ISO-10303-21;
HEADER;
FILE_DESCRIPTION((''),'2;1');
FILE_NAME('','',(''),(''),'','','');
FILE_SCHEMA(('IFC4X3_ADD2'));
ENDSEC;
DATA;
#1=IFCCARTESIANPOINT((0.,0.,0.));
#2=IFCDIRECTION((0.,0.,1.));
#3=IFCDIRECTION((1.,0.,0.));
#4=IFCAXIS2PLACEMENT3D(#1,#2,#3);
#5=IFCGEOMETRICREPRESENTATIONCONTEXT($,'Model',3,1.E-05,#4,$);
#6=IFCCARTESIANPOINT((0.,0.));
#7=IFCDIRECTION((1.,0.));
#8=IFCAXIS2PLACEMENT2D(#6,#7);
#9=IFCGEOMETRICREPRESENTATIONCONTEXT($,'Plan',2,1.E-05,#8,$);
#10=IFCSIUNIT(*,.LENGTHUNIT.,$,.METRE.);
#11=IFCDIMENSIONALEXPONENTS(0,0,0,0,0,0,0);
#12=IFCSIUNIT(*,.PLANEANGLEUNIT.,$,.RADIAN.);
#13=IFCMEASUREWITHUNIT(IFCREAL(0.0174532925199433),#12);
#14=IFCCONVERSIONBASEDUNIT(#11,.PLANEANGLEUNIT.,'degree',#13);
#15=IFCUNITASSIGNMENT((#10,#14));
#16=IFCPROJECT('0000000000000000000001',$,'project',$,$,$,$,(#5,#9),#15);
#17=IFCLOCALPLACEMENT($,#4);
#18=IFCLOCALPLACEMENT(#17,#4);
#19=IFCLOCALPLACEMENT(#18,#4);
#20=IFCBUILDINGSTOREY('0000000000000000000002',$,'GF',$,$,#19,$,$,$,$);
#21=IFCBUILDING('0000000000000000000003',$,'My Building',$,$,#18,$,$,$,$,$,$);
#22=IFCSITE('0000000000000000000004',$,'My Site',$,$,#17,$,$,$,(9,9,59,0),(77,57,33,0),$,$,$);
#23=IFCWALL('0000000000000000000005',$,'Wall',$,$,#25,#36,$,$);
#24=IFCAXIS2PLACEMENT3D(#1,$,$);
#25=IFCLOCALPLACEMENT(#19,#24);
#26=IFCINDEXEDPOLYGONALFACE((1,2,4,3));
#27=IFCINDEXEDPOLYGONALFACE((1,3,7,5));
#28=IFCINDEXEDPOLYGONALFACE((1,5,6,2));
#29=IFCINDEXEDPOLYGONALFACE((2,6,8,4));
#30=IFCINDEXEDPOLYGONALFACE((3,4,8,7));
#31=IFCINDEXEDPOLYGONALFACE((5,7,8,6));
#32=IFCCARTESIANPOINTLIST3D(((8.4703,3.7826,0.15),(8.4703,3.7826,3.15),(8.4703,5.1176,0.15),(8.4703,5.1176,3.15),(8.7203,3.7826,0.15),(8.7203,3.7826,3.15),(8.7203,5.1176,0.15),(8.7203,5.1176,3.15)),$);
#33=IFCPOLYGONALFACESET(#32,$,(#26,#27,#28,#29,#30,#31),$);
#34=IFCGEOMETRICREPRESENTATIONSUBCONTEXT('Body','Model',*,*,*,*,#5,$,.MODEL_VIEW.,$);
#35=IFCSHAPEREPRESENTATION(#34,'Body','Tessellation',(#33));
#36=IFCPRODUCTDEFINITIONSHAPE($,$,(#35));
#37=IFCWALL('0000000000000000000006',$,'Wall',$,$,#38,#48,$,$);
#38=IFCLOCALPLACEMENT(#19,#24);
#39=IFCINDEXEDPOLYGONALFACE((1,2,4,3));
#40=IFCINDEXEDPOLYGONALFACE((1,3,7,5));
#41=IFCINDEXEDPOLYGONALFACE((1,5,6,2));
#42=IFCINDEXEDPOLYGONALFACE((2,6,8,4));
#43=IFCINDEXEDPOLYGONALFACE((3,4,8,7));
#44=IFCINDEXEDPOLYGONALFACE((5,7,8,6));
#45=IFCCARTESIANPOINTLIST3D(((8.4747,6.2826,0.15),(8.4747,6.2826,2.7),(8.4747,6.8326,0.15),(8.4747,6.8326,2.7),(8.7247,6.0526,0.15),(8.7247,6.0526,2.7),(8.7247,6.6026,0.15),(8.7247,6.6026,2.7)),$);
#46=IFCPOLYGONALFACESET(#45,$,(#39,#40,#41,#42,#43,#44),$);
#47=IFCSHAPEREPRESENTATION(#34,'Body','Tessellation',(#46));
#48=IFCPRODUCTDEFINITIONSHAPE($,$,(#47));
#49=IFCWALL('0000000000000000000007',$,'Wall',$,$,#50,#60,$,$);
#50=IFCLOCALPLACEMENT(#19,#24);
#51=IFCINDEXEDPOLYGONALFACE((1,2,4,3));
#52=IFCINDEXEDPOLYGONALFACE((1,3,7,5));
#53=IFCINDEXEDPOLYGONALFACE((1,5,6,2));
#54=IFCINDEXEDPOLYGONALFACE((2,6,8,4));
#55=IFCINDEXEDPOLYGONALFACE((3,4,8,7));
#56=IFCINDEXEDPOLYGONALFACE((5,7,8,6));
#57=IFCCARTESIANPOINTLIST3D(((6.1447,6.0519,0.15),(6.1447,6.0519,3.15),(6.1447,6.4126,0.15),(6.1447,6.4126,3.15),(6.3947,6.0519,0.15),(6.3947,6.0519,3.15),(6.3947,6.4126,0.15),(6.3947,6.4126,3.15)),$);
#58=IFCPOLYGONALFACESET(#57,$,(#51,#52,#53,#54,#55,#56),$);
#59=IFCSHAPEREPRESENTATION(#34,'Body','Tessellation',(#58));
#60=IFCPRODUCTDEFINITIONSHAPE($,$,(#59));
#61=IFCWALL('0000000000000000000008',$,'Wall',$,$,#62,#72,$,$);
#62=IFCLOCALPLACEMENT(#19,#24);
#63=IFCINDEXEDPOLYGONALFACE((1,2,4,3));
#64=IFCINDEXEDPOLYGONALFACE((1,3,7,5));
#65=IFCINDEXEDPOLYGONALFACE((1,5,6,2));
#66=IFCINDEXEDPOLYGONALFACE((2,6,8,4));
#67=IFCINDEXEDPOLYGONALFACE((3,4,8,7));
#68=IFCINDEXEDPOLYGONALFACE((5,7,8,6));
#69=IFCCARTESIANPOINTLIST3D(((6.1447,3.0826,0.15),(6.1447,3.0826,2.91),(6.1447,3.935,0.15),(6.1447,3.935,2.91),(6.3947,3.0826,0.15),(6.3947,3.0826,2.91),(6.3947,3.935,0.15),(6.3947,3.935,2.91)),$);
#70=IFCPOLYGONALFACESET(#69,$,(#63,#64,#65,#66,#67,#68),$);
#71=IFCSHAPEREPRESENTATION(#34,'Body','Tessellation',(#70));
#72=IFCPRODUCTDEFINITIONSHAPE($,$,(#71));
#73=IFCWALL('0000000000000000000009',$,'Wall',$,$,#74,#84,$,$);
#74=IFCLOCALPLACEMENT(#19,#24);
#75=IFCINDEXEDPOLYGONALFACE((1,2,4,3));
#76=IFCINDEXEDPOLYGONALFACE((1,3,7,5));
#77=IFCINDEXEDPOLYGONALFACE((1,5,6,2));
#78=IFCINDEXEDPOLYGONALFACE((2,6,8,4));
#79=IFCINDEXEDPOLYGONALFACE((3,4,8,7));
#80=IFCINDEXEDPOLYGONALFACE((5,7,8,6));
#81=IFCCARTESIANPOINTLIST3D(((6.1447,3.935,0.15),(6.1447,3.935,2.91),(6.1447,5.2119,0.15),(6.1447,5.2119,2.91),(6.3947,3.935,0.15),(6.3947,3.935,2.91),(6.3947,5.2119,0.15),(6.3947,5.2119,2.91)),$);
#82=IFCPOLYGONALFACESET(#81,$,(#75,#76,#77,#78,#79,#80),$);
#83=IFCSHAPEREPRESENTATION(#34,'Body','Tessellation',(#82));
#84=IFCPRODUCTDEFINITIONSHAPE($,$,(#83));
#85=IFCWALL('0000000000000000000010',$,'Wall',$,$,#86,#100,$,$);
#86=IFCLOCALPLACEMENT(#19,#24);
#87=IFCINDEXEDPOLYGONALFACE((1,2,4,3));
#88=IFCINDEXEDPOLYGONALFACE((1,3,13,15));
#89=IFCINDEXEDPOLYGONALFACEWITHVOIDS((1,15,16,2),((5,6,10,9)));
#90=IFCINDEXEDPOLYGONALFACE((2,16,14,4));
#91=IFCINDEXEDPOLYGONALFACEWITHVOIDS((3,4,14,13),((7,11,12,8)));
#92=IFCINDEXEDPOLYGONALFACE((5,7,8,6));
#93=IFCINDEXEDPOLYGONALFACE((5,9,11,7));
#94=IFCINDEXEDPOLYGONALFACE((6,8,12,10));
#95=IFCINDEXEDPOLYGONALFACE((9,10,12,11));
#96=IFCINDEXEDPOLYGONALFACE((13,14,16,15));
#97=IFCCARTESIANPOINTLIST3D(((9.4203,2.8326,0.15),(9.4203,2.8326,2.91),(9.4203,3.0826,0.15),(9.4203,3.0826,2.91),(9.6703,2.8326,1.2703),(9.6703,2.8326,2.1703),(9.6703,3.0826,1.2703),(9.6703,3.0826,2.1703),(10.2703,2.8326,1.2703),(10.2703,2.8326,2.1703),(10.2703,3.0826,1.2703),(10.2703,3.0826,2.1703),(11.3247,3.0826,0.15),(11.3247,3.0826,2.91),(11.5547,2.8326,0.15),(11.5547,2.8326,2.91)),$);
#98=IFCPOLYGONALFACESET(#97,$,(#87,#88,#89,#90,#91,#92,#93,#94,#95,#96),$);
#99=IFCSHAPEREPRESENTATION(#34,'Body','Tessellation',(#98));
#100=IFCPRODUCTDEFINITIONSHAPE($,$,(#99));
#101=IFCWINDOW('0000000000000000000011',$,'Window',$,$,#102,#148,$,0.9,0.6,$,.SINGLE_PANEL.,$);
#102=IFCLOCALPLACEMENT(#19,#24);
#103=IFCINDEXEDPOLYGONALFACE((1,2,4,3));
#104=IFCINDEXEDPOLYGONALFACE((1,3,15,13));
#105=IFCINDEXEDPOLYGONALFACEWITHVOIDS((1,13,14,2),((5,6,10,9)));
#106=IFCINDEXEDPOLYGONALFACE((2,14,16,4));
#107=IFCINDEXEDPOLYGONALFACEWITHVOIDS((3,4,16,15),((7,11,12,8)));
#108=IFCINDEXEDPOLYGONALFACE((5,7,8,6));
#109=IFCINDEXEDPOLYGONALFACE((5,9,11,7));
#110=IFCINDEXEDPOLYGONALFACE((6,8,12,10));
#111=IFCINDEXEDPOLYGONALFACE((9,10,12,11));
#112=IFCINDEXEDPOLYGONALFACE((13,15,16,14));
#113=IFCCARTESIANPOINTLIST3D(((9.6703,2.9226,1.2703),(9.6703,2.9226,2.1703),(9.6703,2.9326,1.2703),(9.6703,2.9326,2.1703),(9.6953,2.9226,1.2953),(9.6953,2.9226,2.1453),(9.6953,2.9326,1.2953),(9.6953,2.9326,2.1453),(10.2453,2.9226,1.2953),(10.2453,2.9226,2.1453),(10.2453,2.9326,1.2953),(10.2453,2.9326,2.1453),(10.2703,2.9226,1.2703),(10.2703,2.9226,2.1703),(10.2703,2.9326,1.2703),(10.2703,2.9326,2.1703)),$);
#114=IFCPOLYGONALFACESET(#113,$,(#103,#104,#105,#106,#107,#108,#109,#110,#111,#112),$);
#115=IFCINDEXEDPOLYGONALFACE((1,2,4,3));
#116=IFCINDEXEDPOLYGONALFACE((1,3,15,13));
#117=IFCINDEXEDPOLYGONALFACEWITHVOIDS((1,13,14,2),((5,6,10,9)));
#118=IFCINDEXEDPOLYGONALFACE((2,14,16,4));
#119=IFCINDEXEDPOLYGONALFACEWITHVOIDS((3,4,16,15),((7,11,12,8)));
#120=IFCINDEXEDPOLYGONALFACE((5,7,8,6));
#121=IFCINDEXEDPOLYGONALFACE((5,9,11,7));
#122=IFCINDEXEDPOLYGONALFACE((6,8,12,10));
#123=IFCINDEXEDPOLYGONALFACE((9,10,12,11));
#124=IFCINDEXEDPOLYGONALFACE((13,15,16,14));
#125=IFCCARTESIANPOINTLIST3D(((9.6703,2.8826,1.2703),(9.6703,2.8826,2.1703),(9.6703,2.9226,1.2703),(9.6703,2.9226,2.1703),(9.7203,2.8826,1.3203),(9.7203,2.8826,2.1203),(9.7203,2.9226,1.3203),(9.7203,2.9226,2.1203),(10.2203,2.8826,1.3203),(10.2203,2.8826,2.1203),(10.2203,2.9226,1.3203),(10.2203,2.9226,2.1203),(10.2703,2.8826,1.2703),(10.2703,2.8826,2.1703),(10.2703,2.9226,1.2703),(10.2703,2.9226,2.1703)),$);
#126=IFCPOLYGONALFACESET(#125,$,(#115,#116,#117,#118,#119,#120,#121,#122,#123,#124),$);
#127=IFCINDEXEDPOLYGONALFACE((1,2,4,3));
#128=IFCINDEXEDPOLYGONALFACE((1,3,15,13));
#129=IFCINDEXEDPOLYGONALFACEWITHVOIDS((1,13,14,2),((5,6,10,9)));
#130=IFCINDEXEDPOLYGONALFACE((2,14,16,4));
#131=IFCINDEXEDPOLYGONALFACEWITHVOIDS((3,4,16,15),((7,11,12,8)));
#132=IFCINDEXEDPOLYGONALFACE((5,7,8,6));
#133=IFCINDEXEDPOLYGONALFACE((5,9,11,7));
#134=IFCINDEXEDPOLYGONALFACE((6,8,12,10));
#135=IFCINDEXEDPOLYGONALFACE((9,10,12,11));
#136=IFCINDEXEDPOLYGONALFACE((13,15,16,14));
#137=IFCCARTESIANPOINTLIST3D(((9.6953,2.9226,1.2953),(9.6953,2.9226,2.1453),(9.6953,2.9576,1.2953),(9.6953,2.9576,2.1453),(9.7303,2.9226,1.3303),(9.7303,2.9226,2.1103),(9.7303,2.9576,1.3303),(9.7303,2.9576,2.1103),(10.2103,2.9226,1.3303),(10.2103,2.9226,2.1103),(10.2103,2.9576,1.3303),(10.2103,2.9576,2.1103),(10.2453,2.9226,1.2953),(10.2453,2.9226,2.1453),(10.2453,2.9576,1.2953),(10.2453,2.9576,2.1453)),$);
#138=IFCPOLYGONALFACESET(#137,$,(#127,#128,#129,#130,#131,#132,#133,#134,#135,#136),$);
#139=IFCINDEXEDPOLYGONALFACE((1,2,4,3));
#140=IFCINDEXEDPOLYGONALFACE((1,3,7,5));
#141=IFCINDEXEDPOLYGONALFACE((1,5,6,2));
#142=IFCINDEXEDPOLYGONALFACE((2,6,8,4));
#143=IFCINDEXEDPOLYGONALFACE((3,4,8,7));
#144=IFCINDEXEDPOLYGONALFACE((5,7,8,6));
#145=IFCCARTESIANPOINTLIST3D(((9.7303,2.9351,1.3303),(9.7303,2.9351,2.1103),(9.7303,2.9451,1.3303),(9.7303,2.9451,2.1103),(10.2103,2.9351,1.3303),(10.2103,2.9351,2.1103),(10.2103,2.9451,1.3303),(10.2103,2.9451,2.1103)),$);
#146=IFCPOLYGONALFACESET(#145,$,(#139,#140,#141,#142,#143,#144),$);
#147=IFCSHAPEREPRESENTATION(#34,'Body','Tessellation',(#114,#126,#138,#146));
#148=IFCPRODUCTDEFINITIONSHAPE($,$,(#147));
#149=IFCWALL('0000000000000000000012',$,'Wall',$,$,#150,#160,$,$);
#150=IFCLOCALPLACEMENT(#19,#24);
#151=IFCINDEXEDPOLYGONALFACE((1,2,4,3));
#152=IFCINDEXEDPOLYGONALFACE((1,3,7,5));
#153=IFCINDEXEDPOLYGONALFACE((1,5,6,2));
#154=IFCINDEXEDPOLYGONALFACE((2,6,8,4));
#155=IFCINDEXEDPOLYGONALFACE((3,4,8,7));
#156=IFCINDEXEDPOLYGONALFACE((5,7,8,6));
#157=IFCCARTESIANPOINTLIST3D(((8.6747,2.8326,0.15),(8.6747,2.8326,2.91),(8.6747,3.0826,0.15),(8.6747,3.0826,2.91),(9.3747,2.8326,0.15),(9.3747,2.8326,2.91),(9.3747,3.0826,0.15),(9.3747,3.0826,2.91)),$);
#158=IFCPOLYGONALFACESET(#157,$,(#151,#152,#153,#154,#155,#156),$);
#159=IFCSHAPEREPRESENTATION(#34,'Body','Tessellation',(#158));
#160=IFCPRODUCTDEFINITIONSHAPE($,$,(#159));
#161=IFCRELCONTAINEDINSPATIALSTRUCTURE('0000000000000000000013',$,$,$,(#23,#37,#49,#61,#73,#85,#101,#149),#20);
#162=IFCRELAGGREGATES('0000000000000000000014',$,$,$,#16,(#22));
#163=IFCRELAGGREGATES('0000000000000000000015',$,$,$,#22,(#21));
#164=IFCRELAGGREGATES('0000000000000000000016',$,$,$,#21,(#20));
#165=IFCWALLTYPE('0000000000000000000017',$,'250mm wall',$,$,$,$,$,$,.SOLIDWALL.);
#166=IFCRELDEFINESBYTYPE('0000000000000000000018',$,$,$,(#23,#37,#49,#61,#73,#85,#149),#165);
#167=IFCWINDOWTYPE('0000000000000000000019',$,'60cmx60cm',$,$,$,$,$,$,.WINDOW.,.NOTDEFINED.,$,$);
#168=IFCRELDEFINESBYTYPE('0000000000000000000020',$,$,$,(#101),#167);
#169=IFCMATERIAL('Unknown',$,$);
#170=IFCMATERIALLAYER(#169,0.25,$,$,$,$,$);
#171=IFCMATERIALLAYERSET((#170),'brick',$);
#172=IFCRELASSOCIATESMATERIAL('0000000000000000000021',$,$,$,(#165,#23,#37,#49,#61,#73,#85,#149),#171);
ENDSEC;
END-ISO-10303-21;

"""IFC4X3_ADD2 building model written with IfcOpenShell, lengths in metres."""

from ifc_helpers import new_model, entity, si_unit, converted_unit, frame, origin_with_axes, origin_2d_with_axis, place, context, subcontext, project, spatial, line, indexed_curve, outline, extrude, shape, source, transform, mapped, material, layer, layer_set, layer_usage, type_object, type_shapes, element, fill, save


model = new_model("IFC4X3_ADD2")

# Units and contexts
model_context = context("Model", 3, precision=1e-05, world=origin_with_axes())
plan_context = context("Plan", 2, precision=1e-05, world=origin_2d_with_axis())
body_context_1 = subcontext(model_context, "Body", "Model", "MODEL_VIEW")
body_context_2 = subcontext(plan_context, "Body", "Plan", "PLAN_VIEW")
ifc_project = project(units=[si_unit("LENGTHUNIT", "METRE"), converted_unit("PLANEANGLEUNIT", "degree", entity("IfcReal", 0.0174532925199433), si_unit("PLANEANGLEUNIT", "RADIAN"), dimensions=[0, 0, 0, 0, 0, 0, 0])], contexts=[model_context, plan_context])

# Site, building, storey
site_placement = place(None, origin_with_axes())
site = spatial("IfcSite", under=ifc_project, at=site_placement, Name="My Site", RefLatitude=(9, 9, 59, 0), RefLongitude=(77, 57, 33, 0))
building_placement = place(site_placement, origin_with_axes())
building = spatial("IfcBuilding", under=site, at=building_placement, Name="My Building")
storey_placement = place(building_placement, origin_with_axes())
storey = spatial("IfcBuildingStorey", under=building, at=storey_placement, Name="GF")

# Walls
ifc_material_1 = material(Name="Unknown")
ifc_layer_1 = layer(ifc_material_1, 0.25)
ifc_layer_set_1 = layer_set([ifc_layer_1], Name="brick")
ifc_layer_usage_1 = layer_usage(ifc_layer_set_1, "AXIS2", "POSITIVE", 0.0)
wall_type_1 = type_object("IfcWallType", Name="250mm wall", PredefinedType="SOLIDWALL", material=ifc_layer_set_1)
wall_1_placement = place(storey_placement, frame((8.7203, 3.7826, 0.15), z_axis=(0.0, 0.0, 1.0), x_axis=(0.0, 1.0, 0.0)))
element("IfcWall", 1, at=wall_1_placement, inside=storey, type_object=wall_type_1, material=ifc_layer_usage_1, Name="Wall", context=body_context_1, shape_type="SweptSolid", body=[
    extrude(outline(indexed_curve([(0.0, 0.0), (0.0, 0.25), (1.335, 0.25), (1.335, 0.0)], segments=[line(1, 2, 3, 4, 1)])), origin_with_axes(), (0.0, 0.0, 1.0), 3.0),
])
ifc_layer_usage_2 = layer_usage(ifc_layer_set_1, "AXIS2", "POSITIVE", 0.0)
wall_2_placement = place(storey_placement, frame((8.7247, 6.0526, 0.15), z_axis=(0.0, 0.0, 1.0), x_axis=(0.0, 1.0, 0.0)))
element("IfcWall", 2, at=wall_2_placement, inside=storey, type_object=wall_type_1, material=ifc_layer_usage_2, Name="Wall", context=body_context_1, shape_type="SweptSolid", body=[
    extrude(outline(indexed_curve([(0.0, 0.0), (0.23, 0.25), (0.78, 0.25), (0.55, 0.0)], segments=[line(1, 2, 3, 4, 1)])), origin_with_axes(), (0.0, 0.0, 1.0), 2.55),
])
ifc_layer_usage_3 = layer_usage(ifc_layer_set_1, "AXIS2", "POSITIVE", 0.0)
wall_3_placement = place(storey_placement, frame((6.3947, 6.0519, 0.15), z_axis=(0.0, 0.0, 1.0), x_axis=(0.0, 1.0, 0.0)))
element("IfcWall", 3, at=wall_3_placement, inside=storey, type_object=wall_type_1, material=ifc_layer_usage_3, Name="Wall", context=body_context_1, shape_type="SweptSolid", body=[
    extrude(outline(indexed_curve([(0.0, 0.0), (0.0, 0.25), (0.3607, 0.25), (0.3607, 0.0)], segments=[line(1, 2, 3, 4, 1)])), origin_with_axes(), (0.0, 0.0, 1.0), 3.0),
])
ifc_layer_usage_4 = layer_usage(ifc_layer_set_1, "AXIS2", "POSITIVE", 0.0)
wall_4_placement = place(storey_placement, frame((6.3947, 3.0826, 0.15), z_axis=(0.0, 0.0, 1.0), x_axis=(0.0, 1.0, 0.0)))
element("IfcWall", 4, at=wall_4_placement, inside=storey, type_object=wall_type_1, material=ifc_layer_usage_4, Name="Wall", context=body_context_1, shape_type="SweptSolid", body=[
    extrude(outline(indexed_curve([(0.0, 0.0), (0.0, 0.25), (0.8524, 0.25), (0.8524, 0.0)], segments=[line(1, 2, 3, 4, 1)])), origin_with_axes(), (0.0, 0.0, 1.0), 2.76),
])
ifc_layer_usage_5 = layer_usage(ifc_layer_set_1, "AXIS2", "POSITIVE", 0.0)
wall_5_placement = place(storey_placement, frame((6.3947, 3.935, 0.15), z_axis=(0.0, 0.0, 1.0), x_axis=(0.0, 1.0, 0.0)))
element("IfcWall", 5, at=wall_5_placement, inside=storey, type_object=wall_type_1, material=ifc_layer_usage_5, Name="Wall", context=body_context_1, shape_type="SweptSolid", body=[
    extrude(outline(indexed_curve([(0.0, 0.0), (0.0, 0.25), (1.2768, 0.25), (1.2768, 0.0)], segments=[line(1, 2, 3, 4, 1)])), origin_with_axes(), (0.0, 0.0, 1.0), 2.76),
])

# Wall, opening, window
ifc_layer_usage_6 = layer_usage(ifc_layer_set_1, "AXIS2", "POSITIVE", 0.0)
wall_6_placement = place(storey_placement, frame((9.4203, 2.8326, 0.15), z_axis=(0.0, 0.0, 1.0), x_axis=(1.0, 0.0, 0.0)))
wall_6 = element("IfcWall", 6, at=wall_6_placement, inside=storey, type_object=wall_type_1, material=ifc_layer_usage_6, Name="Wall", context=body_context_1, shape_type="SweptSolid", body=[
    extrude(outline(indexed_curve([(0.0, 0.0), (0.0, 0.25), (1.9043, 0.25), (2.1343, 0.0)], segments=[line(1, 2, 3, 4, 1)])), origin_with_axes(), (0.0, 0.0, 1.0), 2.76),
])
shared_shape_1 = source(origin_with_axes(), body_context_1, "Body", "SweptSolid", [
    extrude(outline(indexed_curve([(0.0, 0.0), (0.6, 0.0), (0.6, 0.9), (0.0, 0.9)], segments=[line(1, 2, 3, 4, 1)])), frame((0.0, -0.6, 0.0), z_axis=(0.0, -1.0, 0.0), x_axis=(1.0, 0.0, 0.0)), (0.0, 0.0, -1.0), 1.2),
])
opening_1_placement = place(wall_6_placement, frame((0.25, 0.0, 1.1203), z_axis=(0.0, 0.0, 1.0), x_axis=(1.0, 0.0, 0.0)))
opening_1 = element("IfcOpeningElement", 7, at=opening_1_placement, cuts=wall_6, PredefinedType="OPENING", context=body_context_1, shape_type="MappedRepresentation", body=[
    mapped(shared_shape_1, transform((0.0, 0.0, 0.0), x_axis=(1.0, 0.0, 0.0), y_axis=(0.0, 1.0, 0.0), z_axis=(0.0, 0.0, 1.0), scale=1.0)),
])
window_type = type_object("IfcWindowType", Name="60cmx60cm", PartitioningType="NOTDEFINED", PredefinedType="WINDOW")
shared_shape_2 = source(origin_with_axes(), body_context_1, "Body", "SweptSolid", [
    extrude(outline(indexed_curve([(0.0, 0.0), (0.6, 0.0), (0.6, 0.9), (0.0, 0.9)], segments=[line(1, 2, 3, 4, 1)]), holes=[indexed_curve([(0.025, 0.025), (0.575, 0.025), (0.575, 0.875), (0.025, 0.875)], segments=[line(1, 2, 3, 4, 1)])]), frame((0.0, 0.09, 0.0), z_axis=(0.0, -1.0, 0.0), x_axis=(1.0, 0.0, 0.0)), (0.0, 0.0, -1.0), 0.01),
    extrude(outline(indexed_curve([(0.0, 0.0), (0.6, 0.0), (0.6, 0.9), (0.0, 0.9)], segments=[line(1, 2, 3, 4, 1)]), holes=[indexed_curve([(0.05, 0.05), (0.55, 0.05), (0.55, 0.85), (0.05, 0.85)], segments=[line(1, 2, 3, 4, 1)])]), frame((0.0, 0.05, 0.0), z_axis=(0.0, -1.0, 0.0), x_axis=(1.0, 0.0, 0.0)), (0.0, 0.0, -1.0), 0.04),
    extrude(outline(indexed_curve([(0.0, 0.0), (0.55, 0.0), (0.55, 0.85), (0.0, 0.85)], segments=[line(1, 2, 3, 4, 1)]), holes=[indexed_curve([(0.035, 0.035), (0.515, 0.035), (0.515, 0.815), (0.035, 0.815)], segments=[line(1, 2, 3, 4, 1)])]), frame((0.025, 0.09, 0.025), z_axis=(0.0, -1.0, 0.0), x_axis=(1.0, 0.0, 0.0)), (0.0, 0.0, -1.0), 0.035),
    extrude(outline(indexed_curve([(0.035, 0.035), (0.515, 0.035), (0.515, 0.815), (0.035, 0.815)], segments=[line(1, 2, 3, 4, 1)])), frame((0.025, 0.1025, 0.025), z_axis=(0.0, -1.0, 0.0), x_axis=(1.0, 0.0, 0.0)), (0.0, 0.0, -1.0), 0.01),
])
shared_shape_3 = source(origin_with_axes(), body_context_2, "Body", "Curve2D", [
    entity("IfcIndexedPolyCurve", entity("IfcCartesianPointList2D", [[0.05, 0.05], [0.55, 0.05]])),
    entity("IfcIndexedPolyCurve", entity("IfcCartesianPointList2D", [[0.0, 0.1], [0.025, 0.1], [0.025, 0.09], [0.05, 0.09], [0.05, 0.05], [0.0, 0.05]]), [entity("IfcLineIndex", [1, 2, 3, 4, 5, 6, 1])]),
    entity("IfcIndexedPolyCurve", entity("IfcCartesianPointList2D", [[0.6, 0.1], [0.575, 0.1], [0.575, 0.09], [0.55, 0.09], [0.55, 0.05], [0.6, 0.05]]), [entity("IfcLineIndex", [1, 2, 3, 4, 5, 6, 1])]),
    entity("IfcIndexedPolyCurve", entity("IfcCartesianPointList2D", [[0.025, 0.09], [0.06, 0.09], [0.06, 0.125], [0.025, 0.125]]), [entity("IfcLineIndex", [1, 2, 3, 4, 1])]),
    entity("IfcIndexedPolyCurve", entity("IfcCartesianPointList2D", [[0.575, 0.09], [0.54, 0.09], [0.54, 0.125], [0.575, 0.125]]), [entity("IfcLineIndex", [1, 2, 3, 4, 1])]),
    entity("IfcIndexedPolyCurve", entity("IfcCartesianPointList2D", [[0.06, 0.09], [0.54, 0.09]])),
    entity("IfcIndexedPolyCurve", entity("IfcCartesianPointList2D", [[0.06, 0.125], [0.54, 0.125]])),
    entity("IfcIndexedPolyCurve", entity("IfcCartesianPointList2D", [[0.06, 0.1075], [0.54, 0.1075]])),
])
type_shapes(window_type, [shared_shape_2, shared_shape_3])
window_1_placement = place(opening_1_placement, origin_with_axes())
window_1 = element("IfcWindow", 8, at=window_1_placement, inside=storey, type_object=window_type, Name="Window", OverallHeight=0.9, OverallWidth=0.6, PartitioningType="SINGLE_PANEL", shapes=[
    shape(body_context_1, "Body", "MappedRepresentation", [mapped(shared_shape_2, transform((0.0, 0.0, 0.0), x_axis=(1.0, 0.0, 0.0), y_axis=(0.0, 1.0, 0.0), z_axis=(0.0, 0.0, 1.0), scale=1.0))]),
    shape(body_context_2, "Body", "MappedRepresentation", [mapped(shared_shape_3, transform((0.0, 0.0, 0.0), x_axis=(1.0, 0.0, 0.0), y_axis=(0.0, 1.0, 0.0), z_axis=(0.0, 0.0, 1.0), scale=1.0))]),
])
fill(opening_1, window_1)

# Wall
ifc_layer_usage_7 = layer_usage(ifc_layer_set_1, "AXIS2", "POSITIVE", 0.0)
wall_7_placement = place(storey_placement, frame((8.6747, 2.8326, 0.15), z_axis=(0.0, 0.0, 1.0), x_axis=(1.0, 0.0, 0.0)))
element("IfcWall", 9, at=wall_7_placement, inside=storey, type_object=wall_type_1, material=ifc_layer_usage_7, Name="Wall", context=body_context_1, shape_type="SweptSolid", body=[
    extrude(outline(indexed_curve([(0.0, 0.0), (0.0, 0.25), (0.7, 0.25), (0.7, 0.0)], segments=[line(1, 2, 3, 4, 1)])), origin_with_axes(), (0.0, 0.0, 1.0), 2.76),
])

save(model, "model.ifc")
